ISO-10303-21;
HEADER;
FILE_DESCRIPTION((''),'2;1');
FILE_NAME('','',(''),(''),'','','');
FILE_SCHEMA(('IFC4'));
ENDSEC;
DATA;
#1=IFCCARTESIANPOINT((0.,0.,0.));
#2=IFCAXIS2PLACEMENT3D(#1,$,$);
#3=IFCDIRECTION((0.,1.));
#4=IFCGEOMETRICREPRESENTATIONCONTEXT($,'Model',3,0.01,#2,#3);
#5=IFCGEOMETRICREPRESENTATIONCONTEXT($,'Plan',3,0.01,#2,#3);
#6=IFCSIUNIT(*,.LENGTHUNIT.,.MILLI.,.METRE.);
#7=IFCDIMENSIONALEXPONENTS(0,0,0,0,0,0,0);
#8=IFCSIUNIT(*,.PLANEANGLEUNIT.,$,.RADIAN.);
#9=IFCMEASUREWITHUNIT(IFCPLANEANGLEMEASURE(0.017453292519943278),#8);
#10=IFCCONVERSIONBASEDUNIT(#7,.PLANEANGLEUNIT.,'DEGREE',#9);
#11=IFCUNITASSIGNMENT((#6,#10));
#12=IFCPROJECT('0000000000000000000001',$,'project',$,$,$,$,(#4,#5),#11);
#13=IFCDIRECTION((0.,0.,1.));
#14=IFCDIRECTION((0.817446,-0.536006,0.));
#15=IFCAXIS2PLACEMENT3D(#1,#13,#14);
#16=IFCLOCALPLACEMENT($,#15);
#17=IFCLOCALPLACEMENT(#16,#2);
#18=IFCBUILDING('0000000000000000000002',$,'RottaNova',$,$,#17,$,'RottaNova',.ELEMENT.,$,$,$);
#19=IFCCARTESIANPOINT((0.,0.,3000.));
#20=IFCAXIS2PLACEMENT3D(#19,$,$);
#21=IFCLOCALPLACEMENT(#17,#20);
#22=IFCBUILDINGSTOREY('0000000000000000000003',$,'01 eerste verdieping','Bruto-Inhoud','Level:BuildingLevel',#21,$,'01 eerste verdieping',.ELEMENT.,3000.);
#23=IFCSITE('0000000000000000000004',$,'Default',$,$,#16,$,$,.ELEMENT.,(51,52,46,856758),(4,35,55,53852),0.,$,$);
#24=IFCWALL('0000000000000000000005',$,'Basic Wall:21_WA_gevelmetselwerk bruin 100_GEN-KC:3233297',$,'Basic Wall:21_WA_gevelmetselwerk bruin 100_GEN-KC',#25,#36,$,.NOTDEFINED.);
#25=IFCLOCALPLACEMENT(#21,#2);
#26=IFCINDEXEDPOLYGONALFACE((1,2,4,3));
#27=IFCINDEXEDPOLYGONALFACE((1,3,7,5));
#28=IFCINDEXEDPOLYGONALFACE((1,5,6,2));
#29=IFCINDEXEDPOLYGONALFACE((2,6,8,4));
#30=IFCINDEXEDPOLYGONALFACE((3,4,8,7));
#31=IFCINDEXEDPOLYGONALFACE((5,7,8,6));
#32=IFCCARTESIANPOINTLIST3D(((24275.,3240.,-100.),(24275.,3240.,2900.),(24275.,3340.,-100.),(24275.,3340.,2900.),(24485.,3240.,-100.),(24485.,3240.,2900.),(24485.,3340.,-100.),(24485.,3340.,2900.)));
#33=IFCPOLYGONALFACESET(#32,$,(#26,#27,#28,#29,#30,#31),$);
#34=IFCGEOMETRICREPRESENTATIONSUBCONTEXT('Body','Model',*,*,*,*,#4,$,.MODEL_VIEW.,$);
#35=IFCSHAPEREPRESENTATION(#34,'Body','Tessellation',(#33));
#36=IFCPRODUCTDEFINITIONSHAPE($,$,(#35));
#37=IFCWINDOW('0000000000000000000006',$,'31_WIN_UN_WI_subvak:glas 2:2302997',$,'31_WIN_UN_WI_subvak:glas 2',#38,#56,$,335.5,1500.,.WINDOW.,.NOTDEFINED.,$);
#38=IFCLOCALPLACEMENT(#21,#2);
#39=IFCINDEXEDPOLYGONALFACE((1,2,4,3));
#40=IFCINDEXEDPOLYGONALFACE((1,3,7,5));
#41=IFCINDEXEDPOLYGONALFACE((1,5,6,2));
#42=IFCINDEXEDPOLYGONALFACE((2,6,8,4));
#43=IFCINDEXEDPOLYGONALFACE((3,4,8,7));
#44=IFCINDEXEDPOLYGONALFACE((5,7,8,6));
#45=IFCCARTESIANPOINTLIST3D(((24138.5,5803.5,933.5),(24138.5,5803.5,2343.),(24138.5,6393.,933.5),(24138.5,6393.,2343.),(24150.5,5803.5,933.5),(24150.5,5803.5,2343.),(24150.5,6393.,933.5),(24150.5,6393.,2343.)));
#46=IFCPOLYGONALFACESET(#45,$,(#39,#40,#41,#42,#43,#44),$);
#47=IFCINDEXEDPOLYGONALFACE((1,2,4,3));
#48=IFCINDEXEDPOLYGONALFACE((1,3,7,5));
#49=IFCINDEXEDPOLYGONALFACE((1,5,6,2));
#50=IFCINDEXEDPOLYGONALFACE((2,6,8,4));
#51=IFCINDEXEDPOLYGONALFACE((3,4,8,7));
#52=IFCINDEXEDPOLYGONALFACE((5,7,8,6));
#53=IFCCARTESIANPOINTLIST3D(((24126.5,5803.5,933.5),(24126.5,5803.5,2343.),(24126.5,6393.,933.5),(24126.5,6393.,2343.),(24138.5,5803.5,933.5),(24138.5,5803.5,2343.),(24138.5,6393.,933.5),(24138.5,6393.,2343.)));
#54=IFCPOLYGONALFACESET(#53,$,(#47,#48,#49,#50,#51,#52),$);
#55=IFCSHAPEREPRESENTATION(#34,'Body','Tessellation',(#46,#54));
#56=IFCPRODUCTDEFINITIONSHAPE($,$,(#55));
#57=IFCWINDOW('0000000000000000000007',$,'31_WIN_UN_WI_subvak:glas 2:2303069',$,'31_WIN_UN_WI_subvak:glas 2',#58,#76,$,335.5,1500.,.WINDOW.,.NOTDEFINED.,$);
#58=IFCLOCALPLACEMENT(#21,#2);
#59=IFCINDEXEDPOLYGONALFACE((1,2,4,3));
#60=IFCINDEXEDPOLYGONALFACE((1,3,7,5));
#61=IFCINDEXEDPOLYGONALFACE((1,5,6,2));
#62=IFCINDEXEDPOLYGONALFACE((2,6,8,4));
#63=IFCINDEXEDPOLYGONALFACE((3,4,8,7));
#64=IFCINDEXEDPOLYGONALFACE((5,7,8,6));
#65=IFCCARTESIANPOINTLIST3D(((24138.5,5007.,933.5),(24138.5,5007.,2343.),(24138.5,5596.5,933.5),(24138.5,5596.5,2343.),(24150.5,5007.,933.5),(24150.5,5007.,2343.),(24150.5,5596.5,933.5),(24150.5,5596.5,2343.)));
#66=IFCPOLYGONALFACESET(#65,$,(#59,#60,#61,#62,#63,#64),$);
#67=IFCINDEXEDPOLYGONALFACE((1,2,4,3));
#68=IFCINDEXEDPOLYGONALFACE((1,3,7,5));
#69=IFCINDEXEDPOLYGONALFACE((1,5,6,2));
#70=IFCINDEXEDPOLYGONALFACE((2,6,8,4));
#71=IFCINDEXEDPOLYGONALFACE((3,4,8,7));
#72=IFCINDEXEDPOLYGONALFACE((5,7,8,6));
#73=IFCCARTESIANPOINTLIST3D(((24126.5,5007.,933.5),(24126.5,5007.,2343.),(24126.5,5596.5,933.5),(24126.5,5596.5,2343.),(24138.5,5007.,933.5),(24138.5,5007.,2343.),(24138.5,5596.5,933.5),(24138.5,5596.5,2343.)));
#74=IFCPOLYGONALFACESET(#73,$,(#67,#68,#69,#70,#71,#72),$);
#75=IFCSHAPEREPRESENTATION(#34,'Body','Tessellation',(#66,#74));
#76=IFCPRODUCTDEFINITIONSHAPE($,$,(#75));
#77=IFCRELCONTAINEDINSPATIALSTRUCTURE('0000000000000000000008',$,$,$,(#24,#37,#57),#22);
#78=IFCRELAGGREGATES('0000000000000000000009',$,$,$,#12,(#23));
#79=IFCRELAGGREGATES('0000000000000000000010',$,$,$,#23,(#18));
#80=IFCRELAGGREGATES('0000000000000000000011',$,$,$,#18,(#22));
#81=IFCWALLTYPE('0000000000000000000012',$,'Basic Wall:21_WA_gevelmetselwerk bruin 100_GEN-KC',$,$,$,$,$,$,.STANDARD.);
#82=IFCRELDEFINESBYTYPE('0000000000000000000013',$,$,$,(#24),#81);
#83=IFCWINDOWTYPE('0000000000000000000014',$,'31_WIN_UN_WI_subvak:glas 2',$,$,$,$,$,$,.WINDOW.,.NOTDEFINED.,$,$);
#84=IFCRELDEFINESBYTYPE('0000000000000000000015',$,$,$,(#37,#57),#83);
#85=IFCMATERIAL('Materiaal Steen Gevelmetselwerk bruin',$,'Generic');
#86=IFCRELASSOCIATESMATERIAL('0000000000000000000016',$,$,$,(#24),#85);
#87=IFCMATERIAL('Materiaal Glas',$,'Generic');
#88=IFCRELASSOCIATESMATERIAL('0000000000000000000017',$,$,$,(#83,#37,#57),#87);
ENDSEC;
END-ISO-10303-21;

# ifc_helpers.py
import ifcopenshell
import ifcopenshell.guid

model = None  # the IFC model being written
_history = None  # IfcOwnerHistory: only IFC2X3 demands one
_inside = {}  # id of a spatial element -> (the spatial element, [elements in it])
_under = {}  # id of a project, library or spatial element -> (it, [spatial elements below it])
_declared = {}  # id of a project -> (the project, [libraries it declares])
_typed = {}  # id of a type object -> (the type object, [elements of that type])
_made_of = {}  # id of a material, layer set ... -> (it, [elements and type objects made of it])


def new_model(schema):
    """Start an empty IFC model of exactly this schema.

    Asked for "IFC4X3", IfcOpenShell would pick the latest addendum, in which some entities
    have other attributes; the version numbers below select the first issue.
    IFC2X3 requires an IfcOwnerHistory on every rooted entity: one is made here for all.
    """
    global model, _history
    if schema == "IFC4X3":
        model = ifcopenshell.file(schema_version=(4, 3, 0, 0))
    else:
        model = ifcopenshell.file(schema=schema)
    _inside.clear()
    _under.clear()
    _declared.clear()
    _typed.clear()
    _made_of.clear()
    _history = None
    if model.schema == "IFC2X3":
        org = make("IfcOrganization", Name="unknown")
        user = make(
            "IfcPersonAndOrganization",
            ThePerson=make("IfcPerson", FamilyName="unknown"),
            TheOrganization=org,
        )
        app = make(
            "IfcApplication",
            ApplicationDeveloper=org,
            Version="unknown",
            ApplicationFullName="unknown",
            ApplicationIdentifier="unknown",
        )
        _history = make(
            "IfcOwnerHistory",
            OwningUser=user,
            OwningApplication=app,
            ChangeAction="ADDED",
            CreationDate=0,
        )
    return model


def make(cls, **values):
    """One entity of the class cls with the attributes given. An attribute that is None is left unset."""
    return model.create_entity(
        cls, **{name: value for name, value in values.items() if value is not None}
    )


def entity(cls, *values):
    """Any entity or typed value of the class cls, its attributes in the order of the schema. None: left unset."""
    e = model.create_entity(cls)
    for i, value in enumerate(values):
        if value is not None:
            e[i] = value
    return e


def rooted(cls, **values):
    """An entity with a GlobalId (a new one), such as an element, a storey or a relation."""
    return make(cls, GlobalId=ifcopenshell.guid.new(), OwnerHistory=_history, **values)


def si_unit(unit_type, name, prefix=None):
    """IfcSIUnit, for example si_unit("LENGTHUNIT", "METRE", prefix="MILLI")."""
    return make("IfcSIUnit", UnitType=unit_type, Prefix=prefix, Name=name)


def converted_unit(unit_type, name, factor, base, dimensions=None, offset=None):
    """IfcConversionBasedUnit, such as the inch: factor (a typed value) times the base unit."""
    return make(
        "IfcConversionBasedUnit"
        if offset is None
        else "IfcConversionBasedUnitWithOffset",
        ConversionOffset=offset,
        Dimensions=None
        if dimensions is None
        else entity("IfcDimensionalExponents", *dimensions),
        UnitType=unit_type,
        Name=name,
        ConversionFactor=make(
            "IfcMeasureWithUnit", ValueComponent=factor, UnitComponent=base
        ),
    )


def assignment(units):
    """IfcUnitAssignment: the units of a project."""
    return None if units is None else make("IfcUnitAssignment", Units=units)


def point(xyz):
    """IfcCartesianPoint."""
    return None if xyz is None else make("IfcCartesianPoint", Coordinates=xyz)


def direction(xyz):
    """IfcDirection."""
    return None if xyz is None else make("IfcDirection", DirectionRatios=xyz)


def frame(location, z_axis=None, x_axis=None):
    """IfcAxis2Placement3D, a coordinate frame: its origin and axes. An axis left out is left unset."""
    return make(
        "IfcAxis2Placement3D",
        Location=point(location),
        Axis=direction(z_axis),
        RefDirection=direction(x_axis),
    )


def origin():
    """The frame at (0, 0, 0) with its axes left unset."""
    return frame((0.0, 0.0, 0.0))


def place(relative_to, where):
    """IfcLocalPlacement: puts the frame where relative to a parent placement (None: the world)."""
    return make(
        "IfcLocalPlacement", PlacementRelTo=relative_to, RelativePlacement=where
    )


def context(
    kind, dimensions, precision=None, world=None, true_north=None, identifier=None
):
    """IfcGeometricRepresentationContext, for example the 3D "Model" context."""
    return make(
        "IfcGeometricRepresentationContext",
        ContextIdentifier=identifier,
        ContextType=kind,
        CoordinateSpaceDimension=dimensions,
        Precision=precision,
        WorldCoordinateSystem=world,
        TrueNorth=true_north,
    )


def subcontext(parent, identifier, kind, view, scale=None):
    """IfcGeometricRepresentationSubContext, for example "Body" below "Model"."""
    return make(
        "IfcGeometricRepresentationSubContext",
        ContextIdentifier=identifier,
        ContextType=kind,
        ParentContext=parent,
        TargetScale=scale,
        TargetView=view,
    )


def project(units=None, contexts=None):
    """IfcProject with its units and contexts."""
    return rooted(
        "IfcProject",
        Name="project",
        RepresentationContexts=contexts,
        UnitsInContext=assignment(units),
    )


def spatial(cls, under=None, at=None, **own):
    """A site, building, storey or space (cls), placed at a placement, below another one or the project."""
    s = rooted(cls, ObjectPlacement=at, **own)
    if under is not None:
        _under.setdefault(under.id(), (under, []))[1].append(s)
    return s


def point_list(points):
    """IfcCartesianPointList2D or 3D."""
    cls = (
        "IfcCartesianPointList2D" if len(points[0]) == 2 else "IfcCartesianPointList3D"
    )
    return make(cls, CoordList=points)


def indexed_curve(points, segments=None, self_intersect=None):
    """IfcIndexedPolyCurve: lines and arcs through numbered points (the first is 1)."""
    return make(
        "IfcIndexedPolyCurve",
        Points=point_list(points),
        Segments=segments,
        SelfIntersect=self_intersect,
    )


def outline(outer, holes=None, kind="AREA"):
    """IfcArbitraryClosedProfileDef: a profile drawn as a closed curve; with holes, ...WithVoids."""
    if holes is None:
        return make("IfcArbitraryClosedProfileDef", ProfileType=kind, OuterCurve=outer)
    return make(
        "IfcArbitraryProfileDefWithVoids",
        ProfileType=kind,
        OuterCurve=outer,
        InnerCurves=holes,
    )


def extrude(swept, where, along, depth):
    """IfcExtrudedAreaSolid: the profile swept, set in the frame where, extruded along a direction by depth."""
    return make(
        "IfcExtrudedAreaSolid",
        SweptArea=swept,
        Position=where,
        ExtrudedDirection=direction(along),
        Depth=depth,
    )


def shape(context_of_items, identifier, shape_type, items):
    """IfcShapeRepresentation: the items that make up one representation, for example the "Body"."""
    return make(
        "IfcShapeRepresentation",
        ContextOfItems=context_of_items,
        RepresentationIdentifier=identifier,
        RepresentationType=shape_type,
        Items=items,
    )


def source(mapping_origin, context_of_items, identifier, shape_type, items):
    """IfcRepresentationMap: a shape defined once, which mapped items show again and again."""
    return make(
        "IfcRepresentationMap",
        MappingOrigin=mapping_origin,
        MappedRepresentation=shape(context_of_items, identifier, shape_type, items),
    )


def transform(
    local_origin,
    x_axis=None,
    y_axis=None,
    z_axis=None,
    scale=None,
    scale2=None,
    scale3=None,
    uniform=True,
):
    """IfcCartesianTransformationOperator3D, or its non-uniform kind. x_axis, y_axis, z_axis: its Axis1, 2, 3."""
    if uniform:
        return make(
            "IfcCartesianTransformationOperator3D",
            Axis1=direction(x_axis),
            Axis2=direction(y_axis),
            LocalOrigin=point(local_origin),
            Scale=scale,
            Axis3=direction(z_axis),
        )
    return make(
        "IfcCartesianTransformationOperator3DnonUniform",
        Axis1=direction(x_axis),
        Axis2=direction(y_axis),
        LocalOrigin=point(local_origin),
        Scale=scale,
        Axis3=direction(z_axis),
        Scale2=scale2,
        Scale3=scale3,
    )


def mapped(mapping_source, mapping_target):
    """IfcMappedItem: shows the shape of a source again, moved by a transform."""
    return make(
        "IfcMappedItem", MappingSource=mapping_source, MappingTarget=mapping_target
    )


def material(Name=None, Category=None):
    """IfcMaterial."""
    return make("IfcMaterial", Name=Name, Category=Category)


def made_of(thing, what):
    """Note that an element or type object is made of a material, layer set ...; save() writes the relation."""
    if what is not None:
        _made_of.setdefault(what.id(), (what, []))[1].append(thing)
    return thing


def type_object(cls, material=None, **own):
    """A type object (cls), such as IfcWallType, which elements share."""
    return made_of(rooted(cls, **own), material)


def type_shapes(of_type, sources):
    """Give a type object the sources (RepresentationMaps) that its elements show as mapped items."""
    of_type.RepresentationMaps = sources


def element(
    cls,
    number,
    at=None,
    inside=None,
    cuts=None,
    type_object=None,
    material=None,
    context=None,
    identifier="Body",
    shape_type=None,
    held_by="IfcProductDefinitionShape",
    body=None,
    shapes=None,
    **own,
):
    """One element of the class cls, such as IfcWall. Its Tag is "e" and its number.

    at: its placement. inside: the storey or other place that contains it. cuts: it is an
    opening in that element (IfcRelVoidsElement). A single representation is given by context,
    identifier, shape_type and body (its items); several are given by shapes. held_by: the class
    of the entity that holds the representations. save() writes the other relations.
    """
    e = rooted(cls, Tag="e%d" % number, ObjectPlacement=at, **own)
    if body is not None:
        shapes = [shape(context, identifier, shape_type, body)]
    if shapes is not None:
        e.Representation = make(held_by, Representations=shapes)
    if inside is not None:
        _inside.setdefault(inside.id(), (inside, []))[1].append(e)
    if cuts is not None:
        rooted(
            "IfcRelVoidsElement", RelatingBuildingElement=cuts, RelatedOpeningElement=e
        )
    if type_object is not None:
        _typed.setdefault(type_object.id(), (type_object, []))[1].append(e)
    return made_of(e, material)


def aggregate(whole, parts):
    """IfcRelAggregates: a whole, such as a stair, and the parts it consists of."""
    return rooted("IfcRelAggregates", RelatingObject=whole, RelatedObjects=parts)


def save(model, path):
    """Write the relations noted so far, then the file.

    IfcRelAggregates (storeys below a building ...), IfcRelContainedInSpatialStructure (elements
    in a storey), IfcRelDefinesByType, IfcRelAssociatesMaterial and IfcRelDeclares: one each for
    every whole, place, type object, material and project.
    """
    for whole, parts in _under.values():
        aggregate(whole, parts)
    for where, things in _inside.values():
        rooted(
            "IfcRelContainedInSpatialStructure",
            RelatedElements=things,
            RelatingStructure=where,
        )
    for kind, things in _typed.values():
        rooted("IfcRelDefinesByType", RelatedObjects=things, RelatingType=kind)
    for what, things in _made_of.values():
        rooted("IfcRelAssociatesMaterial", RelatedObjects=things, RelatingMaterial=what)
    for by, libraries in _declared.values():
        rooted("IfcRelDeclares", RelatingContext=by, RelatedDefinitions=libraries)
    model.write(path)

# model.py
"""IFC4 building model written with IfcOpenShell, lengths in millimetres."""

from ifc_helpers import new_model, entity, si_unit, converted_unit, direction, frame, origin, place, context, subcontext, project, spatial, indexed_curve, outline, extrude, source, transform, mapped, material, type_object, type_shapes, element, save


model = new_model("IFC4")

# Units and contexts
model_context = context("Model", 3, precision=0.01, world=origin(), true_north=direction((0.0, 1.0)))
plan_context = context("Plan", 3, precision=0.01, world=origin(), true_north=direction((0.0, 1.0)))
body_context = subcontext(model_context, "Body", "Model", "MODEL_VIEW")
ifc_project = project(units=[si_unit("LENGTHUNIT", "METRE", prefix="MILLI"), converted_unit("PLANEANGLEUNIT", "DEGREE", entity("IfcPlaneAngleMeasure", 0.017453292519943278), si_unit("PLANEANGLEUNIT", "RADIAN"), dimensions=[0, 0, 0, 0, 0, 0, 0])], contexts=[model_context, plan_context])

# Site, building, storey
site_placement = place(None, frame((0.0, 0.0, 0.0), z_axis=(0.0, 0.0, 1.0), x_axis=(0.817446, -0.536006, 0.0)))
site = spatial("IfcSite", under=ifc_project, at=site_placement, Name="Default", CompositionType="ELEMENT", RefLatitude=(51, 52, 46, 856758), RefLongitude=(4, 35, 55, 53852), RefElevation=0.0)
building_placement = place(site_placement, origin())
building = spatial("IfcBuilding", under=site, at=building_placement, Name="RottaNova", LongName="RottaNova", CompositionType="ELEMENT")
storey_placement = place(building_placement, frame((0.0, 0.0, 3000.0)))
storey = spatial("IfcBuildingStorey", under=building, at=storey_placement, Name="01 eerste verdieping", Description="Bruto-Inhoud", ObjectType="Level:BuildingLevel", LongName="01 eerste verdieping", CompositionType="ELEMENT", Elevation=3000.0)

# Shared definitions
ifc_material_1 = material(Name="Materiaal Glas", Category="Generic")

# Wall
ifc_material_2 = material(Name="Materiaal Steen Gevelmetselwerk bruin", Category="Generic")
wall_type_1 = type_object("IfcWallType", Name="Basic Wall:21_WA_gevelmetselwerk bruin 100_GEN-KC", PredefinedType="STANDARD")
wall_1_placement = place(storey_placement, frame((24485.0, 3290.0, -100.0), z_axis=(0.0, 0.0, 1.0), x_axis=(-1.0, 0.0, 0.0)))
element("IfcWall", 1, at=wall_1_placement, inside=storey, type_object=wall_type_1, material=ifc_material_2, Name="Basic Wall:21_WA_gevelmetselwerk bruin 100_GEN-KC:3233297", ObjectType="Basic Wall:21_WA_gevelmetselwerk bruin 100_GEN-KC", PredefinedType="NOTDEFINED", context=body_context, shape_type="SweptSolid", body=[
    extrude(outline(indexed_curve([(210.0, 50.0), (0.0, 50.0), (0.0, -50.0), (210.0, -50.0), (210.0, 50.0)], self_intersect=False)), origin(), (0.0, 0.0, 1.0), 3000.0),
])

# Windows
window_type = type_object("IfcWindowType", Name="31_WIN_UN_WI_subvak:glas 2", PartitioningType="NOTDEFINED", PredefinedType="WINDOW", material=ifc_material_1)
shared_shape_1 = source(origin(), body_context, "Body", "SweptSolid", [
    extrude(outline(indexed_curve([(-6.0, -294.7), (6.0, -294.7), (6.0, 294.7), (-6.0, 294.7), (-6.0, -294.7)], self_intersect=False)), frame((0.0, 6.0, 0.0), z_axis=(0.0, 0.0, 1.0), x_axis=(0.0, -1.0, 0.0)), (0.0, 0.0, 1.0), 1409.5),
    extrude(outline(indexed_curve([(-6.0, -294.8), (6.0, -294.8), (6.0, 294.8), (-6.0, 294.8), (-6.0, -294.8)], self_intersect=False)), frame((0.0, -6.0, 0.0), z_axis=(0.0, 0.0, 1.0), x_axis=(0.0, -1.0, 0.0)), (0.0, 0.0, 1.0), 1409.5),
])
type_shapes(window_type, [shared_shape_1])
for number, where, z_axis, x_axis, name in (
    (2, (24138.5, 6098.2, 933.5), (0.0, 0.0, 1.0), (0.0, -1.0, 0.0), "31_WIN_UN_WI_subvak:glas 2:2302997"),
    (3, (24138.5, 5301.7, 933.5), (0.0, 0.0, 1.0), (0.0, -1.0, 0.0), "31_WIN_UN_WI_subvak:glas 2:2303069"),
):
    element("IfcWindow", number, at=place(storey_placement, frame(where, z_axis=z_axis, x_axis=x_axis)), inside=storey, type_object=window_type, material=ifc_material_1, Name=name, ObjectType="31_WIN_UN_WI_subvak:glas 2", OverallHeight=335.5, OverallWidth=1500.0, PartitioningType="NOTDEFINED", PredefinedType="WINDOW", context=body_context, shape_type="MappedRepresentation", body=[
        mapped(shared_shape_1, transform((0.0, 0.0, 0.0), scale=1.0)),
    ])

save(model, "model.ifc")
